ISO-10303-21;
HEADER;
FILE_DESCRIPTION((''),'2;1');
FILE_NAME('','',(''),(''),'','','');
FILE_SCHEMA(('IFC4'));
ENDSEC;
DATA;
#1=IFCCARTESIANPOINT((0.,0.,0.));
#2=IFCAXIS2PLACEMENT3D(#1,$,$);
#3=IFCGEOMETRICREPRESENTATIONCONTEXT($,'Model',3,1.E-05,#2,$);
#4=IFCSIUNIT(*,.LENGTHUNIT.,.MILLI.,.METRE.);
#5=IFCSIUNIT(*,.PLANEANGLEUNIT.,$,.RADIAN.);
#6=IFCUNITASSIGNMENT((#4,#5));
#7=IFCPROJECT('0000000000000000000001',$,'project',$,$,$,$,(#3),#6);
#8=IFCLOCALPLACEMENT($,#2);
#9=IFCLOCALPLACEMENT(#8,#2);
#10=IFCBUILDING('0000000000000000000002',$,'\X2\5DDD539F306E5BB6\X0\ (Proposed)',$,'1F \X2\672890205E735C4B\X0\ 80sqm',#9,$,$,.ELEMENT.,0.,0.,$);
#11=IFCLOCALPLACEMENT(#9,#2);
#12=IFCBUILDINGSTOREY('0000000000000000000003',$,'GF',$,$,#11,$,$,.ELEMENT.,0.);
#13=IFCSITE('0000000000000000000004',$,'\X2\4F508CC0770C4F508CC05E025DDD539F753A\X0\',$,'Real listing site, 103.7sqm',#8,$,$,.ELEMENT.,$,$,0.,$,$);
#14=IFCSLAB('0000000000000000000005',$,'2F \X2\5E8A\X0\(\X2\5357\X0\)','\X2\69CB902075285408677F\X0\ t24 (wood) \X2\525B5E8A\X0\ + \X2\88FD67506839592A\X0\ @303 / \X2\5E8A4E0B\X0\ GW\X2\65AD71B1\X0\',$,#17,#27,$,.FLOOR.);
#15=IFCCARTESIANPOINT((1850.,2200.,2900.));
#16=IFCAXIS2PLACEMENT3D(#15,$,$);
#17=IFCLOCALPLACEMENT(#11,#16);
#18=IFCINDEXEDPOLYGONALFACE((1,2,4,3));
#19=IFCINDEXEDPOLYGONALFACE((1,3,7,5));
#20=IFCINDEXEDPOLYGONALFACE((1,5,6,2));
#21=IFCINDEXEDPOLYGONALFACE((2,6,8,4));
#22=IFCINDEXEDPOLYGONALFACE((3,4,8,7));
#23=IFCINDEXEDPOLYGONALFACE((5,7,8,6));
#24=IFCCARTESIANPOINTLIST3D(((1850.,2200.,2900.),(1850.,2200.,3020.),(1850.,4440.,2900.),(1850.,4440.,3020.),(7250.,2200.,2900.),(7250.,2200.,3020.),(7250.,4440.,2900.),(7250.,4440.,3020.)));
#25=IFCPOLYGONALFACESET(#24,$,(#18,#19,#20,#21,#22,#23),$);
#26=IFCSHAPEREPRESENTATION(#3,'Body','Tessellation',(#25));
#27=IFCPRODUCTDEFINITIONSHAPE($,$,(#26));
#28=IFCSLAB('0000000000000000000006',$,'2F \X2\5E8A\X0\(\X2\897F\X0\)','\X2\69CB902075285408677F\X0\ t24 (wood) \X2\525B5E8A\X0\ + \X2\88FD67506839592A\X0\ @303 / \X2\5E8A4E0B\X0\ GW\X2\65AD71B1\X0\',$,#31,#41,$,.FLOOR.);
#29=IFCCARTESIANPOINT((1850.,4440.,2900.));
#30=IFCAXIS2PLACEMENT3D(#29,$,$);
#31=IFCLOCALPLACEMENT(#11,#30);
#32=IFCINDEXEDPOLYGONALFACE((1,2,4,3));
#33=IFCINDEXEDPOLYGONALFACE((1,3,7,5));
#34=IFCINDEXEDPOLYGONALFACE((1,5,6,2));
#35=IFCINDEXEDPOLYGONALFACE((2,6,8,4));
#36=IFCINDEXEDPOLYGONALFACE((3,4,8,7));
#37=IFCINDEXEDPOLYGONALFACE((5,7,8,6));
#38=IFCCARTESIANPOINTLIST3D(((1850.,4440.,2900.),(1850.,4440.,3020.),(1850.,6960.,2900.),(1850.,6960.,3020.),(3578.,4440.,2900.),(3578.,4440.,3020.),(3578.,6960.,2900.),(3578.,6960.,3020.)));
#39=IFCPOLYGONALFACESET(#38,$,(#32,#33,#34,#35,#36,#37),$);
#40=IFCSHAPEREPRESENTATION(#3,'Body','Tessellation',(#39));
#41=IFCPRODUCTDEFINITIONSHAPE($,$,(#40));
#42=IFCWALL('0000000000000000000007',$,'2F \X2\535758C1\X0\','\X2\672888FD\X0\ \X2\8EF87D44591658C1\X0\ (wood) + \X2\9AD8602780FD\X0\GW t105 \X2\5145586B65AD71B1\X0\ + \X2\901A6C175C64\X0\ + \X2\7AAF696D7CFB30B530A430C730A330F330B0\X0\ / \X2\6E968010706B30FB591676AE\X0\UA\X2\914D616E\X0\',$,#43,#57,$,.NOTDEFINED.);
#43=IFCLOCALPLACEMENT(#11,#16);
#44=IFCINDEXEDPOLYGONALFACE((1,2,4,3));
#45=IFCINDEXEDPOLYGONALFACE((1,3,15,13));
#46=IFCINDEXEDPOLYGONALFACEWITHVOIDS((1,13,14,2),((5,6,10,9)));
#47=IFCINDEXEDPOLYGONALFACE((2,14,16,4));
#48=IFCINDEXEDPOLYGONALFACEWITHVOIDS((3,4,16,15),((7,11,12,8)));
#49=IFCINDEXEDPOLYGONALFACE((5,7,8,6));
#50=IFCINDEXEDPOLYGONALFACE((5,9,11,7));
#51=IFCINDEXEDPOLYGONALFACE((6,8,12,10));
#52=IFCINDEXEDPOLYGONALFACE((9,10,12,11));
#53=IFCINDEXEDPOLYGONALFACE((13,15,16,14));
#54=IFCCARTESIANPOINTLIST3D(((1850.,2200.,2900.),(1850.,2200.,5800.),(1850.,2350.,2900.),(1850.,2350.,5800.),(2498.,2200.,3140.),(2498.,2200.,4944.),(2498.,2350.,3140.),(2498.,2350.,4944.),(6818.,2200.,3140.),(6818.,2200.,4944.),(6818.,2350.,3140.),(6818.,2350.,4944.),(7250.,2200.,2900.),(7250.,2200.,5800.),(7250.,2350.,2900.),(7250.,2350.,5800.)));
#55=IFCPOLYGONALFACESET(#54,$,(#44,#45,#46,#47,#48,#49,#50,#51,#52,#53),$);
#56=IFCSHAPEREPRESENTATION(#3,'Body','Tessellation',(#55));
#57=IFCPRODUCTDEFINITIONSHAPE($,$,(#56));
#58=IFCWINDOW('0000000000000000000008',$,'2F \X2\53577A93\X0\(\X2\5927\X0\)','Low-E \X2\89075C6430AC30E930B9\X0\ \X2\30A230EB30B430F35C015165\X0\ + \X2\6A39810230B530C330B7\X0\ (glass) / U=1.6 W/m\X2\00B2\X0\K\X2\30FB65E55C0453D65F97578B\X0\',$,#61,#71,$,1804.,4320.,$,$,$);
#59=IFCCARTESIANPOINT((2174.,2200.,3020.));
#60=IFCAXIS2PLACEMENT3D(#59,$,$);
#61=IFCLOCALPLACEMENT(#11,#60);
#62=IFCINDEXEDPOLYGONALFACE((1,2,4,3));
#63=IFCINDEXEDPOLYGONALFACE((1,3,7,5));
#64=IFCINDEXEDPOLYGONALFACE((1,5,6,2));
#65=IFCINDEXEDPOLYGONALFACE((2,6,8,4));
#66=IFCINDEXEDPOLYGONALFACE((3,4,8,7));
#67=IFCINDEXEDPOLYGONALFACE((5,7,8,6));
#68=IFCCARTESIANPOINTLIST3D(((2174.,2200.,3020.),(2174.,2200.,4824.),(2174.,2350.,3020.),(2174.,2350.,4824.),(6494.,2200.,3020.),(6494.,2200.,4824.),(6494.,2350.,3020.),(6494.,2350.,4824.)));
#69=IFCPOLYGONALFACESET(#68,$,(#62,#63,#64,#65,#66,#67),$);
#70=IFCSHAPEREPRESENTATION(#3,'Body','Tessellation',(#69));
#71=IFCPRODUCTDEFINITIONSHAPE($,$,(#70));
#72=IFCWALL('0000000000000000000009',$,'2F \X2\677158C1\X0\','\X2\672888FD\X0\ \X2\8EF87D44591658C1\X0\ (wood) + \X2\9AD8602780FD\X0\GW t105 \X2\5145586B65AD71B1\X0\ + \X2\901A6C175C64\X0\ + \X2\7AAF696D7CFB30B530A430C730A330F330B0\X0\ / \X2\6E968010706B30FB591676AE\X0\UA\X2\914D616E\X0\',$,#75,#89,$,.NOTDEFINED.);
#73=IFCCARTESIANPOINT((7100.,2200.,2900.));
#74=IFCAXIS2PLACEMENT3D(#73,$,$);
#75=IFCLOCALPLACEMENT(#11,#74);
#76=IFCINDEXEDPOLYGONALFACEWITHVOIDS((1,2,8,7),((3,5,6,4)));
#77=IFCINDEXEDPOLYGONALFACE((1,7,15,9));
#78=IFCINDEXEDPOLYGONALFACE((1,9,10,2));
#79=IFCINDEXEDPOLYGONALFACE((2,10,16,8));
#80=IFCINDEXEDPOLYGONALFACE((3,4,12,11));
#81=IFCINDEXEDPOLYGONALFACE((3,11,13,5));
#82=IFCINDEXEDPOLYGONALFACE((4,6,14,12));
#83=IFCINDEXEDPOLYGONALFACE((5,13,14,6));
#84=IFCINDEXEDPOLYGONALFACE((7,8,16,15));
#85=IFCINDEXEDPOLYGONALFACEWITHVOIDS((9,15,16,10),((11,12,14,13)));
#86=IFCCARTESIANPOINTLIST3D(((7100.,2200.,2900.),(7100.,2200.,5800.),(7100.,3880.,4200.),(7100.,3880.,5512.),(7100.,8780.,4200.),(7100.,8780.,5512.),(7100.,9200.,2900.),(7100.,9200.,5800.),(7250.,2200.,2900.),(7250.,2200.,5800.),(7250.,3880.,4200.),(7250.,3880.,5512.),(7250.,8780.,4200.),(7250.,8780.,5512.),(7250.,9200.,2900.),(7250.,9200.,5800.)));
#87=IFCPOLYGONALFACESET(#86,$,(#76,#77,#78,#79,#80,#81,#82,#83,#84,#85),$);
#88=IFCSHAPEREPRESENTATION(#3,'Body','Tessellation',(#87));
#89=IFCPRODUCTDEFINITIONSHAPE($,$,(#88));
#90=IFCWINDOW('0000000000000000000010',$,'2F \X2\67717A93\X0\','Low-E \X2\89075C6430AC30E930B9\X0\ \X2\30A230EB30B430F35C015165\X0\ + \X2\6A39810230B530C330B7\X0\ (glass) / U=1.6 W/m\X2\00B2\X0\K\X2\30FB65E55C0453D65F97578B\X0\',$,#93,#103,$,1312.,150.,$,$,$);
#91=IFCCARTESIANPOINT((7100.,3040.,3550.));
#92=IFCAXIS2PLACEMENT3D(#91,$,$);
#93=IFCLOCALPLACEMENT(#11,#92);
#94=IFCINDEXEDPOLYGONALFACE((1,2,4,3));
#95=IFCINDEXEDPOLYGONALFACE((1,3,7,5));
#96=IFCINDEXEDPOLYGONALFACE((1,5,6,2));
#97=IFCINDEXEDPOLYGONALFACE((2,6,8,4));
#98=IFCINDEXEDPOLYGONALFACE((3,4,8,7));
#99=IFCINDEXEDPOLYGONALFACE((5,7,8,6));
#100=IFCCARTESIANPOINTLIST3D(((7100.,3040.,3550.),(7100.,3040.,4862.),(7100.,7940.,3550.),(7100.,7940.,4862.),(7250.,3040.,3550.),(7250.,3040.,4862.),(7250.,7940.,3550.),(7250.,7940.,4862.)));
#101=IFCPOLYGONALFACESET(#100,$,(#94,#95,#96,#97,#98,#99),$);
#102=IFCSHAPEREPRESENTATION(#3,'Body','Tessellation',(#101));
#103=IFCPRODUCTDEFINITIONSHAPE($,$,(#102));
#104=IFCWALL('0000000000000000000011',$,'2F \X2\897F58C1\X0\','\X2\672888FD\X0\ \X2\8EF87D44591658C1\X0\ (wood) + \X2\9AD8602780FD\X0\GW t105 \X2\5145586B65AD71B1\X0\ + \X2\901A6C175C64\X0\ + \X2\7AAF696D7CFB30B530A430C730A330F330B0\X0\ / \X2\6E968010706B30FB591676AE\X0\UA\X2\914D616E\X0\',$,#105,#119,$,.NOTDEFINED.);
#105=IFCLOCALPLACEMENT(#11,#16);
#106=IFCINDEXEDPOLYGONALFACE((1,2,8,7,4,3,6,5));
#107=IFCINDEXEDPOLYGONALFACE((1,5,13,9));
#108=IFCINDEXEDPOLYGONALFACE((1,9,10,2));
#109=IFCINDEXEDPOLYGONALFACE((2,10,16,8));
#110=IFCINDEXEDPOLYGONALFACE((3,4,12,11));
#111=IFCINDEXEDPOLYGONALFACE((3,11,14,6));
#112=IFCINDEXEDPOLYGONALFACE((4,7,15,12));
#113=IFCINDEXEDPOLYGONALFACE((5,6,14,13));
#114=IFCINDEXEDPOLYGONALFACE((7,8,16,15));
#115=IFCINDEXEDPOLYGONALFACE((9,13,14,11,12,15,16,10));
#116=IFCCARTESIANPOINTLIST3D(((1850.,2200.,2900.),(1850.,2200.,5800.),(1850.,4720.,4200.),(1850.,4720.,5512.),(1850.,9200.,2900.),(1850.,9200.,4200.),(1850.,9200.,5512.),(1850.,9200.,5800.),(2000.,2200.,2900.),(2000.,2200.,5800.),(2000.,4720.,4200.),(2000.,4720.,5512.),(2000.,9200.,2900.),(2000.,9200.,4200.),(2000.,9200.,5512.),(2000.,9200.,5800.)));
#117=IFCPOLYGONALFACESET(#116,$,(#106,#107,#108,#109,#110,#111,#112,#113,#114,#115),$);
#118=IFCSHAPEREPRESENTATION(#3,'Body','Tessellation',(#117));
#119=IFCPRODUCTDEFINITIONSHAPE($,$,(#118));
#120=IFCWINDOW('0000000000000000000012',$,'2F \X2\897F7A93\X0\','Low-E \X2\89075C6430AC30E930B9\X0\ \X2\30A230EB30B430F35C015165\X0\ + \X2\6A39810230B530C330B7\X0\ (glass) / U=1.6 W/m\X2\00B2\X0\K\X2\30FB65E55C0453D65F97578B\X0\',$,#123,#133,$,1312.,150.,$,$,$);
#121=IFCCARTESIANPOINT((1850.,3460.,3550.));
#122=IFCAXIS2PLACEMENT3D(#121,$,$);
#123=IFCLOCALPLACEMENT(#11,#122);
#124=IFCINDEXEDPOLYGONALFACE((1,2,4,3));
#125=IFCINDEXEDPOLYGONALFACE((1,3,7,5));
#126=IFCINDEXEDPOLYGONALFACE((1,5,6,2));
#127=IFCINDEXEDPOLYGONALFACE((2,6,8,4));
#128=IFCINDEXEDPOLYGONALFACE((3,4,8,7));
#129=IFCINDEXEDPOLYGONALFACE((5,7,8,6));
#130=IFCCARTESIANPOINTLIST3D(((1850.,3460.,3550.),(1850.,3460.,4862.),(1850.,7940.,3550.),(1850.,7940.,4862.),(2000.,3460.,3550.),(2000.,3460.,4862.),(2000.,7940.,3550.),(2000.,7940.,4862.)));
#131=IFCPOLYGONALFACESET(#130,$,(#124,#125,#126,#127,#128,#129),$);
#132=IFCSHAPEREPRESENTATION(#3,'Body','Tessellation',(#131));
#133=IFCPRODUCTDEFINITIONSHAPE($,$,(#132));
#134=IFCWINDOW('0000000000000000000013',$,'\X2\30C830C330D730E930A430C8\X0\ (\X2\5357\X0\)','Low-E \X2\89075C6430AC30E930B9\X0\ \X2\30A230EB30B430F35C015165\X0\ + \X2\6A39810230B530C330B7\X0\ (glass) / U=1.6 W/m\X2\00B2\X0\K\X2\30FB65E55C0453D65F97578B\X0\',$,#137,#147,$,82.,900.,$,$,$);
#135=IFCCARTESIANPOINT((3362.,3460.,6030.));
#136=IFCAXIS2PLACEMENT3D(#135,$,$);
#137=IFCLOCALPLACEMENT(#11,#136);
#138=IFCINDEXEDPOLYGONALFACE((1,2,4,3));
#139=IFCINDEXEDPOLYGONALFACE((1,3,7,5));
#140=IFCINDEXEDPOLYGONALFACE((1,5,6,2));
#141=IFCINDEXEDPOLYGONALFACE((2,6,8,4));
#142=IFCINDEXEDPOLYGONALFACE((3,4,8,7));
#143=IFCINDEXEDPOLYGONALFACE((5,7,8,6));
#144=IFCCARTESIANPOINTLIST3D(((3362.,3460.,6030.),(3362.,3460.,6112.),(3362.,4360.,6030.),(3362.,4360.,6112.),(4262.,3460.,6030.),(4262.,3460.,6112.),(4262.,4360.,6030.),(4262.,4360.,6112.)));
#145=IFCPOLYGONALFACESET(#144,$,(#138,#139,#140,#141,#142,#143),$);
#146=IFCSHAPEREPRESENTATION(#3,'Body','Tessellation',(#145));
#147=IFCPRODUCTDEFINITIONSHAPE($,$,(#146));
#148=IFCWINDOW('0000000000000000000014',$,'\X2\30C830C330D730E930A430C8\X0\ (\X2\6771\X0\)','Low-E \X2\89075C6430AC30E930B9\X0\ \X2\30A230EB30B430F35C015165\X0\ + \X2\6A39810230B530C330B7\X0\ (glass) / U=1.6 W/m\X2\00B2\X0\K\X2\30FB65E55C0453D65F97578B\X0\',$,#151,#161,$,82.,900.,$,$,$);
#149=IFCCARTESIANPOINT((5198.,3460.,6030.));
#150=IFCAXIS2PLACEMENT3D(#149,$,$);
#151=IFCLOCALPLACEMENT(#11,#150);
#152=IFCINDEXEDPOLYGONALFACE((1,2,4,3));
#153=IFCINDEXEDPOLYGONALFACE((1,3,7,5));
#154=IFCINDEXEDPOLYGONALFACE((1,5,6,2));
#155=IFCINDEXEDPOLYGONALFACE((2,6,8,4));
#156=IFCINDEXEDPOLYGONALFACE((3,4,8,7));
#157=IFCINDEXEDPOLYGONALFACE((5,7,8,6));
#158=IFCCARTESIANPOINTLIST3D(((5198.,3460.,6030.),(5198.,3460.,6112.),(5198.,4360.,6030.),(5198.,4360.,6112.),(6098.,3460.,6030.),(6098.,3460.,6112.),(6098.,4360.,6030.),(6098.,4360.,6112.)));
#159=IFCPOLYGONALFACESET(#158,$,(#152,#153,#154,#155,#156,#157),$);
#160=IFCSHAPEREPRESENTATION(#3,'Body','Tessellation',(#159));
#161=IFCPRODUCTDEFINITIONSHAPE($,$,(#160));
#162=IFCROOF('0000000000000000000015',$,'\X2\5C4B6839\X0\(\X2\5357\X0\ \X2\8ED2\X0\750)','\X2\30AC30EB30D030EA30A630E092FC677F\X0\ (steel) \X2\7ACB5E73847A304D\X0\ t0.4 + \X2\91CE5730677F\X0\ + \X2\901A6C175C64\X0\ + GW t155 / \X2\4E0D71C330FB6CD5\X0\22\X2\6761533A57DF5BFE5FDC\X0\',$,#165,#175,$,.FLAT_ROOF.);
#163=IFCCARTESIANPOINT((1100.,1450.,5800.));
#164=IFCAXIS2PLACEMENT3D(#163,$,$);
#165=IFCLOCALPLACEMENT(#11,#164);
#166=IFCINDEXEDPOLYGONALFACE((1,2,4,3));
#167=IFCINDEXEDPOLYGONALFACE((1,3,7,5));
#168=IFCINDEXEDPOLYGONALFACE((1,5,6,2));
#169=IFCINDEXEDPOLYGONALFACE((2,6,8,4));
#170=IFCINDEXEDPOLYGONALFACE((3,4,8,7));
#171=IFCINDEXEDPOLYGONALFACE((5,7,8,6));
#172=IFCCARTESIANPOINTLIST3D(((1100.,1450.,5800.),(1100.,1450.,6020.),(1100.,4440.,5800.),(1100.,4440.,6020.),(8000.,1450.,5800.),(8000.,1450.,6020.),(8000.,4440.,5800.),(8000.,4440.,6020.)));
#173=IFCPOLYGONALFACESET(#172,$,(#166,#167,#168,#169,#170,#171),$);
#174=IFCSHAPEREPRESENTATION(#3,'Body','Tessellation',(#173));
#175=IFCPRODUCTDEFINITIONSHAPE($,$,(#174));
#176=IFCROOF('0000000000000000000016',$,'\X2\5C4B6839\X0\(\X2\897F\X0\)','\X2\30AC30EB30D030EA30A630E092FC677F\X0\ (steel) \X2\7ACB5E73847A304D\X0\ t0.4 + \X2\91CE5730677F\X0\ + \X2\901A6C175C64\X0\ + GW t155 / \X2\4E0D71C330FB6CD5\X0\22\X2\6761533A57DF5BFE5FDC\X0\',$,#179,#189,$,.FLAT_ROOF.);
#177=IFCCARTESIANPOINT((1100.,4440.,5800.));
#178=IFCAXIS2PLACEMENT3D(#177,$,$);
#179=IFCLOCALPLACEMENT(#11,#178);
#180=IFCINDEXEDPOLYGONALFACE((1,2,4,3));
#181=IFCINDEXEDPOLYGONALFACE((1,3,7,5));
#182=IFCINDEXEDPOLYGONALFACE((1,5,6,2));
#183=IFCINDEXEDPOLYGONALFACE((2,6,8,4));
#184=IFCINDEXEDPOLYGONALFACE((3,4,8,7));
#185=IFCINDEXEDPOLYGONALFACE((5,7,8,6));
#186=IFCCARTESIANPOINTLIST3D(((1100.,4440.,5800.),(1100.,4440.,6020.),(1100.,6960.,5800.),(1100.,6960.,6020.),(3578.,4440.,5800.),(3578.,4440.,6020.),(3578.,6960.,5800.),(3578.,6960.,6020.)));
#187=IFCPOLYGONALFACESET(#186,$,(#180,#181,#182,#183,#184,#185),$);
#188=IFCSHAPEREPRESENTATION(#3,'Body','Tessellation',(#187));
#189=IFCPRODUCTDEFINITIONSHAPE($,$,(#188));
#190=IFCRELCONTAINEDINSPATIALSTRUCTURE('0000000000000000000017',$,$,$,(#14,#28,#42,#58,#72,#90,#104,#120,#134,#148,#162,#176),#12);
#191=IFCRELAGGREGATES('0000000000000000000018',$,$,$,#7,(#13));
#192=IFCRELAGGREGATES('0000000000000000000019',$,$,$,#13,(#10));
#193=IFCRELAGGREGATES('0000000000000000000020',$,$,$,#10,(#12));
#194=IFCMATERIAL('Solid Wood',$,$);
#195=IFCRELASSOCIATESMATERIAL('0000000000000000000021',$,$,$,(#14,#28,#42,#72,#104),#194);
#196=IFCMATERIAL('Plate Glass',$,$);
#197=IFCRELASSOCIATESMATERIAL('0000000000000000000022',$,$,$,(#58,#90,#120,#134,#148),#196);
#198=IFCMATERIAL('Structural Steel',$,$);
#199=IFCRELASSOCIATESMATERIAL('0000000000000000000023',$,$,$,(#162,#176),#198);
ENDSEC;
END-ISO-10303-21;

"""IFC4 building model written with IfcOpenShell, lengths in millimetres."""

from ifc_helpers import new_model, si_unit, frame, frame_2d, origin, place, context, project, spatial, rectangle, extrude, material, element, fill, save


model = new_model("IFC4")

# Units and contexts
model_context = context("Model", 3, precision=1e-05, world=origin())
ifc_project = project(units=[si_unit("LENGTHUNIT", "METRE", prefix="MILLI"), si_unit("PLANEANGLEUNIT", "RADIAN")], contexts=[model_context])

# Site, building, storey
site_placement = place(None, origin())
site = spatial("IfcSite", under=ifc_project, at=site_placement, Name="佐賀県佐賀市川原町", ObjectType="Real listing site, 103.7sqm", CompositionType="ELEMENT", RefElevation=0.0)
building_placement = place(site_placement, origin())
building = spatial("IfcBuilding", under=site, at=building_placement, Name="川原の家 (Proposed)", ObjectType="1F 木造平屋 80sqm", CompositionType="ELEMENT", ElevationOfRefHeight=0.0, ElevationOfTerrain=0.0)
storey_placement = place(building_placement, origin())
storey = spatial("IfcBuildingStorey", under=building, at=storey_placement, Name="GF", CompositionType="ELEMENT", Elevation=0.0)

# Slabs
ifc_material_1 = material(Name="Solid Wood")
slab_1_placement = place(storey_placement, frame((1850.0, 2200.0, 2900.0)))
element("IfcSlab", 1, at=slab_1_placement, inside=storey, material=ifc_material_1, Name="2F 床(南)", Description="構造用合板 t24 (wood) 剛床 + 製材根太 @303 / 床下 GW断熱", PredefinedType="FLOOR", context=model_context, shape_type="SweptSolid", body=[
    extrude(rectangle(XDim=5400.0, YDim=2240.0, at=frame_2d((2700.0, 1120.0))), frame((1850.0, 2200.0, 2900.0)), (0.0, 0.0, 1.0), 120.0),
])
slab_2_placement = place(storey_placement, frame((1850.0, 4440.0, 2900.0)))
element("IfcSlab", 2, at=slab_2_placement, inside=storey, material=ifc_material_1, Name="2F 床(西)", Description="構造用合板 t24 (wood) 剛床 + 製材根太 @303 / 床下 GW断熱", PredefinedType="FLOOR", context=model_context, shape_type="SweptSolid", body=[
    extrude(rectangle(XDim=1728.0, YDim=2520.0, at=frame_2d((864.0, 1260.0))), frame((1850.0, 4440.0, 2900.0)), (0.0, 0.0, 1.0), 120.0),
])

# Walls, openings, windows
wall_1_placement = place(storey_placement, frame((1850.0, 2200.0, 2900.0)))
wall_1 = element("IfcWall", 3, at=wall_1_placement, inside=storey, material=ifc_material_1, Name="2F 南壁", Description="木製 軸組外壁 (wood) + 高性能GW t105 充填断熱 + 通気層 + 窯業系サイディング / 準耐火・外皮UA配慮", PredefinedType="NOTDEFINED", context=model_context, shape_type="SweptSolid", body=[
    extrude(rectangle(XDim=5400.0, YDim=150.0, at=frame_2d((2700.0, 75.0))), frame((1850.0, 2200.0, 2900.0)), (0.0, 0.0, 1.0), 2900.0),
])
opening_1_placement = place(storey_placement, frame((2174.0, 2200.0, 3020.0)))
opening_1 = element("IfcOpeningElement", 4, at=opening_1_placement, cuts=wall_1, PredefinedType="NOTDEFINED", context=model_context, shape_type="SweptSolid", body=[
    extrude(rectangle(XDim=4320.0, YDim=150.0, at=frame_2d((2160.0, 75.0))), frame((2174.0, 2200.0, 3020.0)), (0.0, 0.0, 1.0), 1804.0),
])
ifc_material_2 = material(Name="Plate Glass")
window_1_placement = place(storey_placement, frame((2174.0, 2200.0, 3020.0)))
window_1 = element("IfcWindow", 5, at=window_1_placement, inside=storey, material=ifc_material_2, Name="2F 南窓(大)", Description="Low-E 複層ガラス アルゴン封入 + 樹脂サッシ (glass) / U=1.6 W/m²K・日射取得型", OverallHeight=1804.0, OverallWidth=4320.0, context=model_context, shape_type="SweptSolid", body=[
    extrude(rectangle(XDim=4320.0, YDim=150.0, at=frame_2d((2160.0, 75.0))), frame((2174.0, 2200.0, 3020.0)), (0.0, 0.0, 1.0), 1804.0),
])
fill(opening_1, window_1)
wall_2_placement = place(storey_placement, frame((7100.0, 2200.0, 2900.0)))
wall_2 = element("IfcWall", 6, at=wall_2_placement, inside=storey, material=ifc_material_1, Name="2F 東壁", Description="木製 軸組外壁 (wood) + 高性能GW t105 充填断熱 + 通気層 + 窯業系サイディング / 準耐火・外皮UA配慮", PredefinedType="NOTDEFINED", context=model_context, shape_type="SweptSolid", body=[
    extrude(rectangle(XDim=150.0, YDim=7000.0, at=frame_2d((75.0, 3500.0))), frame((7100.0, 2200.0, 2900.0)), (0.0, 0.0, 1.0), 2900.0),
])
opening_2_placement = place(storey_placement, frame((7100.0, 3040.0, 3550.0)))
opening_2 = element("IfcOpeningElement", 7, at=opening_2_placement, cuts=wall_2, PredefinedType="NOTDEFINED", context=model_context, shape_type="SweptSolid", body=[
    extrude(rectangle(XDim=150.0, YDim=4900.0, at=frame_2d((75.0, 2450.0))), frame((7100.0, 3040.0, 3550.0)), (0.0, 0.0, 1.0), 1312.0),
])
window_2_placement = place(storey_placement, frame((7100.0, 3040.0, 3550.0)))
window_2 = element("IfcWindow", 8, at=window_2_placement, inside=storey, material=ifc_material_2, Name="2F 東窓", Description="Low-E 複層ガラス アルゴン封入 + 樹脂サッシ (glass) / U=1.6 W/m²K・日射取得型", OverallHeight=1312.0, OverallWidth=150.0, context=model_context, shape_type="SweptSolid", body=[
    extrude(rectangle(XDim=150.0, YDim=4900.0, at=frame_2d((75.0, 2450.0))), frame((7100.0, 3040.0, 3550.0)), (0.0, 0.0, 1.0), 1312.0),
])
fill(opening_2, window_2)
wall_3_placement = place(storey_placement, frame((1850.0, 2200.0, 2900.0)))
wall_3 = element("IfcWall", 9, at=wall_3_placement, inside=storey, material=ifc_material_1, Name="2F 西壁", Description="木製 軸組外壁 (wood) + 高性能GW t105 充填断熱 + 通気層 + 窯業系サイディング / 準耐火・外皮UA配慮", PredefinedType="NOTDEFINED", context=model_context, shape_type="SweptSolid", body=[
    extrude(rectangle(XDim=150.0, YDim=7000.0, at=frame_2d((75.0, 3500.0))), frame((1850.0, 2200.0, 2900.0)), (0.0, 0.0, 1.0), 2900.0),
])
opening_3_placement = place(storey_placement, frame((1850.0, 3460.0, 3550.0)))
opening_3 = element("IfcOpeningElement", 10, at=opening_3_placement, cuts=wall_3, PredefinedType="NOTDEFINED", context=model_context, shape_type="SweptSolid", body=[
    extrude(rectangle(XDim=150.0, YDim=4480.0, at=frame_2d((75.0, 2240.0))), frame((1850.0, 3460.0, 3550.0)), (0.0, 0.0, 1.0), 1312.0),
])
window_3_placement = place(storey_placement, frame((1850.0, 3460.0, 3550.0)))
window_3 = element("IfcWindow", 11, at=window_3_placement, inside=storey, material=ifc_material_2, Name="2F 西窓", Description="Low-E 複層ガラス アルゴン封入 + 樹脂サッシ (glass) / U=1.6 W/m²K・日射取得型", OverallHeight=1312.0, OverallWidth=150.0, context=model_context, shape_type="SweptSolid", body=[
    extrude(rectangle(XDim=150.0, YDim=4480.0, at=frame_2d((75.0, 2240.0))), frame((1850.0, 3460.0, 3550.0)), (0.0, 0.0, 1.0), 1312.0),
])
fill(opening_3, window_3)

# Windows
window_4_placement = place(storey_placement, frame((3362.0, 3460.0, 6030.0)))
element("IfcWindow", 12, at=window_4_placement, inside=storey, material=ifc_material_2, Name="トップライト (南)", Description="Low-E 複層ガラス アルゴン封入 + 樹脂サッシ (glass) / U=1.6 W/m²K・日射取得型", OverallHeight=82.0, OverallWidth=900.0, context=model_context, shape_type="SweptSolid", body=[
    extrude(rectangle(XDim=900.0, YDim=900.0, at=frame_2d((450.0, 450.0))), frame((3362.0, 3460.0, 6030.0)), (0.0, 0.0, 1.0), 82.0),
])
window_5_placement = place(storey_placement, frame((5198.0, 3460.0, 6030.0)))
element("IfcWindow", 13, at=window_5_placement, inside=storey, material=ifc_material_2, Name="トップライト (東)", Description="Low-E 複層ガラス アルゴン封入 + 樹脂サッシ (glass) / U=1.6 W/m²K・日射取得型", OverallHeight=82.0, OverallWidth=900.0, context=model_context, shape_type="SweptSolid", body=[
    extrude(rectangle(XDim=900.0, YDim=900.0, at=frame_2d((450.0, 450.0))), frame((5198.0, 3460.0, 6030.0)), (0.0, 0.0, 1.0), 82.0),
])

# Roofs
ifc_material_3 = material(Name="Structural Steel")
roof_1_placement = place(storey_placement, frame((1100.0, 1450.0, 5800.0)))
element("IfcRoof", 14, at=roof_1_placement, inside=storey, material=ifc_material_3, Name="屋根(南 軒750)", Description="ガルバリウム鋼板 (steel) 立平葺き t0.4 + 野地板 + 通気層 + GW t155 / 不燃・法22条区域対応", PredefinedType="FLAT_ROOF", context=model_context, shape_type="SweptSolid", body=[
    extrude(rectangle(XDim=6900.0, YDim=2990.0, at=frame_2d((3450.0, 1495.0))), frame((1100.0, 1450.0, 5800.0)), (0.0, 0.0, 1.0), 220.0),
])
roof_2_placement = place(storey_placement, frame((1100.0, 4440.0, 5800.0)))
element("IfcRoof", 15, at=roof_2_placement, inside=storey, material=ifc_material_3, Name="屋根(西)", Description="ガルバリウム鋼板 (steel) 立平葺き t0.4 + 野地板 + 通気層 + GW t155 / 不燃・法22条区域対応", PredefinedType="FLAT_ROOF", context=model_context, shape_type="SweptSolid", body=[
    extrude(rectangle(XDim=2478.0, YDim=2520.0, at=frame_2d((1239.0, 1260.0))), frame((1100.0, 4440.0, 5800.0)), (0.0, 0.0, 1.0), 220.0),
])

save(model, "model.ifc")
